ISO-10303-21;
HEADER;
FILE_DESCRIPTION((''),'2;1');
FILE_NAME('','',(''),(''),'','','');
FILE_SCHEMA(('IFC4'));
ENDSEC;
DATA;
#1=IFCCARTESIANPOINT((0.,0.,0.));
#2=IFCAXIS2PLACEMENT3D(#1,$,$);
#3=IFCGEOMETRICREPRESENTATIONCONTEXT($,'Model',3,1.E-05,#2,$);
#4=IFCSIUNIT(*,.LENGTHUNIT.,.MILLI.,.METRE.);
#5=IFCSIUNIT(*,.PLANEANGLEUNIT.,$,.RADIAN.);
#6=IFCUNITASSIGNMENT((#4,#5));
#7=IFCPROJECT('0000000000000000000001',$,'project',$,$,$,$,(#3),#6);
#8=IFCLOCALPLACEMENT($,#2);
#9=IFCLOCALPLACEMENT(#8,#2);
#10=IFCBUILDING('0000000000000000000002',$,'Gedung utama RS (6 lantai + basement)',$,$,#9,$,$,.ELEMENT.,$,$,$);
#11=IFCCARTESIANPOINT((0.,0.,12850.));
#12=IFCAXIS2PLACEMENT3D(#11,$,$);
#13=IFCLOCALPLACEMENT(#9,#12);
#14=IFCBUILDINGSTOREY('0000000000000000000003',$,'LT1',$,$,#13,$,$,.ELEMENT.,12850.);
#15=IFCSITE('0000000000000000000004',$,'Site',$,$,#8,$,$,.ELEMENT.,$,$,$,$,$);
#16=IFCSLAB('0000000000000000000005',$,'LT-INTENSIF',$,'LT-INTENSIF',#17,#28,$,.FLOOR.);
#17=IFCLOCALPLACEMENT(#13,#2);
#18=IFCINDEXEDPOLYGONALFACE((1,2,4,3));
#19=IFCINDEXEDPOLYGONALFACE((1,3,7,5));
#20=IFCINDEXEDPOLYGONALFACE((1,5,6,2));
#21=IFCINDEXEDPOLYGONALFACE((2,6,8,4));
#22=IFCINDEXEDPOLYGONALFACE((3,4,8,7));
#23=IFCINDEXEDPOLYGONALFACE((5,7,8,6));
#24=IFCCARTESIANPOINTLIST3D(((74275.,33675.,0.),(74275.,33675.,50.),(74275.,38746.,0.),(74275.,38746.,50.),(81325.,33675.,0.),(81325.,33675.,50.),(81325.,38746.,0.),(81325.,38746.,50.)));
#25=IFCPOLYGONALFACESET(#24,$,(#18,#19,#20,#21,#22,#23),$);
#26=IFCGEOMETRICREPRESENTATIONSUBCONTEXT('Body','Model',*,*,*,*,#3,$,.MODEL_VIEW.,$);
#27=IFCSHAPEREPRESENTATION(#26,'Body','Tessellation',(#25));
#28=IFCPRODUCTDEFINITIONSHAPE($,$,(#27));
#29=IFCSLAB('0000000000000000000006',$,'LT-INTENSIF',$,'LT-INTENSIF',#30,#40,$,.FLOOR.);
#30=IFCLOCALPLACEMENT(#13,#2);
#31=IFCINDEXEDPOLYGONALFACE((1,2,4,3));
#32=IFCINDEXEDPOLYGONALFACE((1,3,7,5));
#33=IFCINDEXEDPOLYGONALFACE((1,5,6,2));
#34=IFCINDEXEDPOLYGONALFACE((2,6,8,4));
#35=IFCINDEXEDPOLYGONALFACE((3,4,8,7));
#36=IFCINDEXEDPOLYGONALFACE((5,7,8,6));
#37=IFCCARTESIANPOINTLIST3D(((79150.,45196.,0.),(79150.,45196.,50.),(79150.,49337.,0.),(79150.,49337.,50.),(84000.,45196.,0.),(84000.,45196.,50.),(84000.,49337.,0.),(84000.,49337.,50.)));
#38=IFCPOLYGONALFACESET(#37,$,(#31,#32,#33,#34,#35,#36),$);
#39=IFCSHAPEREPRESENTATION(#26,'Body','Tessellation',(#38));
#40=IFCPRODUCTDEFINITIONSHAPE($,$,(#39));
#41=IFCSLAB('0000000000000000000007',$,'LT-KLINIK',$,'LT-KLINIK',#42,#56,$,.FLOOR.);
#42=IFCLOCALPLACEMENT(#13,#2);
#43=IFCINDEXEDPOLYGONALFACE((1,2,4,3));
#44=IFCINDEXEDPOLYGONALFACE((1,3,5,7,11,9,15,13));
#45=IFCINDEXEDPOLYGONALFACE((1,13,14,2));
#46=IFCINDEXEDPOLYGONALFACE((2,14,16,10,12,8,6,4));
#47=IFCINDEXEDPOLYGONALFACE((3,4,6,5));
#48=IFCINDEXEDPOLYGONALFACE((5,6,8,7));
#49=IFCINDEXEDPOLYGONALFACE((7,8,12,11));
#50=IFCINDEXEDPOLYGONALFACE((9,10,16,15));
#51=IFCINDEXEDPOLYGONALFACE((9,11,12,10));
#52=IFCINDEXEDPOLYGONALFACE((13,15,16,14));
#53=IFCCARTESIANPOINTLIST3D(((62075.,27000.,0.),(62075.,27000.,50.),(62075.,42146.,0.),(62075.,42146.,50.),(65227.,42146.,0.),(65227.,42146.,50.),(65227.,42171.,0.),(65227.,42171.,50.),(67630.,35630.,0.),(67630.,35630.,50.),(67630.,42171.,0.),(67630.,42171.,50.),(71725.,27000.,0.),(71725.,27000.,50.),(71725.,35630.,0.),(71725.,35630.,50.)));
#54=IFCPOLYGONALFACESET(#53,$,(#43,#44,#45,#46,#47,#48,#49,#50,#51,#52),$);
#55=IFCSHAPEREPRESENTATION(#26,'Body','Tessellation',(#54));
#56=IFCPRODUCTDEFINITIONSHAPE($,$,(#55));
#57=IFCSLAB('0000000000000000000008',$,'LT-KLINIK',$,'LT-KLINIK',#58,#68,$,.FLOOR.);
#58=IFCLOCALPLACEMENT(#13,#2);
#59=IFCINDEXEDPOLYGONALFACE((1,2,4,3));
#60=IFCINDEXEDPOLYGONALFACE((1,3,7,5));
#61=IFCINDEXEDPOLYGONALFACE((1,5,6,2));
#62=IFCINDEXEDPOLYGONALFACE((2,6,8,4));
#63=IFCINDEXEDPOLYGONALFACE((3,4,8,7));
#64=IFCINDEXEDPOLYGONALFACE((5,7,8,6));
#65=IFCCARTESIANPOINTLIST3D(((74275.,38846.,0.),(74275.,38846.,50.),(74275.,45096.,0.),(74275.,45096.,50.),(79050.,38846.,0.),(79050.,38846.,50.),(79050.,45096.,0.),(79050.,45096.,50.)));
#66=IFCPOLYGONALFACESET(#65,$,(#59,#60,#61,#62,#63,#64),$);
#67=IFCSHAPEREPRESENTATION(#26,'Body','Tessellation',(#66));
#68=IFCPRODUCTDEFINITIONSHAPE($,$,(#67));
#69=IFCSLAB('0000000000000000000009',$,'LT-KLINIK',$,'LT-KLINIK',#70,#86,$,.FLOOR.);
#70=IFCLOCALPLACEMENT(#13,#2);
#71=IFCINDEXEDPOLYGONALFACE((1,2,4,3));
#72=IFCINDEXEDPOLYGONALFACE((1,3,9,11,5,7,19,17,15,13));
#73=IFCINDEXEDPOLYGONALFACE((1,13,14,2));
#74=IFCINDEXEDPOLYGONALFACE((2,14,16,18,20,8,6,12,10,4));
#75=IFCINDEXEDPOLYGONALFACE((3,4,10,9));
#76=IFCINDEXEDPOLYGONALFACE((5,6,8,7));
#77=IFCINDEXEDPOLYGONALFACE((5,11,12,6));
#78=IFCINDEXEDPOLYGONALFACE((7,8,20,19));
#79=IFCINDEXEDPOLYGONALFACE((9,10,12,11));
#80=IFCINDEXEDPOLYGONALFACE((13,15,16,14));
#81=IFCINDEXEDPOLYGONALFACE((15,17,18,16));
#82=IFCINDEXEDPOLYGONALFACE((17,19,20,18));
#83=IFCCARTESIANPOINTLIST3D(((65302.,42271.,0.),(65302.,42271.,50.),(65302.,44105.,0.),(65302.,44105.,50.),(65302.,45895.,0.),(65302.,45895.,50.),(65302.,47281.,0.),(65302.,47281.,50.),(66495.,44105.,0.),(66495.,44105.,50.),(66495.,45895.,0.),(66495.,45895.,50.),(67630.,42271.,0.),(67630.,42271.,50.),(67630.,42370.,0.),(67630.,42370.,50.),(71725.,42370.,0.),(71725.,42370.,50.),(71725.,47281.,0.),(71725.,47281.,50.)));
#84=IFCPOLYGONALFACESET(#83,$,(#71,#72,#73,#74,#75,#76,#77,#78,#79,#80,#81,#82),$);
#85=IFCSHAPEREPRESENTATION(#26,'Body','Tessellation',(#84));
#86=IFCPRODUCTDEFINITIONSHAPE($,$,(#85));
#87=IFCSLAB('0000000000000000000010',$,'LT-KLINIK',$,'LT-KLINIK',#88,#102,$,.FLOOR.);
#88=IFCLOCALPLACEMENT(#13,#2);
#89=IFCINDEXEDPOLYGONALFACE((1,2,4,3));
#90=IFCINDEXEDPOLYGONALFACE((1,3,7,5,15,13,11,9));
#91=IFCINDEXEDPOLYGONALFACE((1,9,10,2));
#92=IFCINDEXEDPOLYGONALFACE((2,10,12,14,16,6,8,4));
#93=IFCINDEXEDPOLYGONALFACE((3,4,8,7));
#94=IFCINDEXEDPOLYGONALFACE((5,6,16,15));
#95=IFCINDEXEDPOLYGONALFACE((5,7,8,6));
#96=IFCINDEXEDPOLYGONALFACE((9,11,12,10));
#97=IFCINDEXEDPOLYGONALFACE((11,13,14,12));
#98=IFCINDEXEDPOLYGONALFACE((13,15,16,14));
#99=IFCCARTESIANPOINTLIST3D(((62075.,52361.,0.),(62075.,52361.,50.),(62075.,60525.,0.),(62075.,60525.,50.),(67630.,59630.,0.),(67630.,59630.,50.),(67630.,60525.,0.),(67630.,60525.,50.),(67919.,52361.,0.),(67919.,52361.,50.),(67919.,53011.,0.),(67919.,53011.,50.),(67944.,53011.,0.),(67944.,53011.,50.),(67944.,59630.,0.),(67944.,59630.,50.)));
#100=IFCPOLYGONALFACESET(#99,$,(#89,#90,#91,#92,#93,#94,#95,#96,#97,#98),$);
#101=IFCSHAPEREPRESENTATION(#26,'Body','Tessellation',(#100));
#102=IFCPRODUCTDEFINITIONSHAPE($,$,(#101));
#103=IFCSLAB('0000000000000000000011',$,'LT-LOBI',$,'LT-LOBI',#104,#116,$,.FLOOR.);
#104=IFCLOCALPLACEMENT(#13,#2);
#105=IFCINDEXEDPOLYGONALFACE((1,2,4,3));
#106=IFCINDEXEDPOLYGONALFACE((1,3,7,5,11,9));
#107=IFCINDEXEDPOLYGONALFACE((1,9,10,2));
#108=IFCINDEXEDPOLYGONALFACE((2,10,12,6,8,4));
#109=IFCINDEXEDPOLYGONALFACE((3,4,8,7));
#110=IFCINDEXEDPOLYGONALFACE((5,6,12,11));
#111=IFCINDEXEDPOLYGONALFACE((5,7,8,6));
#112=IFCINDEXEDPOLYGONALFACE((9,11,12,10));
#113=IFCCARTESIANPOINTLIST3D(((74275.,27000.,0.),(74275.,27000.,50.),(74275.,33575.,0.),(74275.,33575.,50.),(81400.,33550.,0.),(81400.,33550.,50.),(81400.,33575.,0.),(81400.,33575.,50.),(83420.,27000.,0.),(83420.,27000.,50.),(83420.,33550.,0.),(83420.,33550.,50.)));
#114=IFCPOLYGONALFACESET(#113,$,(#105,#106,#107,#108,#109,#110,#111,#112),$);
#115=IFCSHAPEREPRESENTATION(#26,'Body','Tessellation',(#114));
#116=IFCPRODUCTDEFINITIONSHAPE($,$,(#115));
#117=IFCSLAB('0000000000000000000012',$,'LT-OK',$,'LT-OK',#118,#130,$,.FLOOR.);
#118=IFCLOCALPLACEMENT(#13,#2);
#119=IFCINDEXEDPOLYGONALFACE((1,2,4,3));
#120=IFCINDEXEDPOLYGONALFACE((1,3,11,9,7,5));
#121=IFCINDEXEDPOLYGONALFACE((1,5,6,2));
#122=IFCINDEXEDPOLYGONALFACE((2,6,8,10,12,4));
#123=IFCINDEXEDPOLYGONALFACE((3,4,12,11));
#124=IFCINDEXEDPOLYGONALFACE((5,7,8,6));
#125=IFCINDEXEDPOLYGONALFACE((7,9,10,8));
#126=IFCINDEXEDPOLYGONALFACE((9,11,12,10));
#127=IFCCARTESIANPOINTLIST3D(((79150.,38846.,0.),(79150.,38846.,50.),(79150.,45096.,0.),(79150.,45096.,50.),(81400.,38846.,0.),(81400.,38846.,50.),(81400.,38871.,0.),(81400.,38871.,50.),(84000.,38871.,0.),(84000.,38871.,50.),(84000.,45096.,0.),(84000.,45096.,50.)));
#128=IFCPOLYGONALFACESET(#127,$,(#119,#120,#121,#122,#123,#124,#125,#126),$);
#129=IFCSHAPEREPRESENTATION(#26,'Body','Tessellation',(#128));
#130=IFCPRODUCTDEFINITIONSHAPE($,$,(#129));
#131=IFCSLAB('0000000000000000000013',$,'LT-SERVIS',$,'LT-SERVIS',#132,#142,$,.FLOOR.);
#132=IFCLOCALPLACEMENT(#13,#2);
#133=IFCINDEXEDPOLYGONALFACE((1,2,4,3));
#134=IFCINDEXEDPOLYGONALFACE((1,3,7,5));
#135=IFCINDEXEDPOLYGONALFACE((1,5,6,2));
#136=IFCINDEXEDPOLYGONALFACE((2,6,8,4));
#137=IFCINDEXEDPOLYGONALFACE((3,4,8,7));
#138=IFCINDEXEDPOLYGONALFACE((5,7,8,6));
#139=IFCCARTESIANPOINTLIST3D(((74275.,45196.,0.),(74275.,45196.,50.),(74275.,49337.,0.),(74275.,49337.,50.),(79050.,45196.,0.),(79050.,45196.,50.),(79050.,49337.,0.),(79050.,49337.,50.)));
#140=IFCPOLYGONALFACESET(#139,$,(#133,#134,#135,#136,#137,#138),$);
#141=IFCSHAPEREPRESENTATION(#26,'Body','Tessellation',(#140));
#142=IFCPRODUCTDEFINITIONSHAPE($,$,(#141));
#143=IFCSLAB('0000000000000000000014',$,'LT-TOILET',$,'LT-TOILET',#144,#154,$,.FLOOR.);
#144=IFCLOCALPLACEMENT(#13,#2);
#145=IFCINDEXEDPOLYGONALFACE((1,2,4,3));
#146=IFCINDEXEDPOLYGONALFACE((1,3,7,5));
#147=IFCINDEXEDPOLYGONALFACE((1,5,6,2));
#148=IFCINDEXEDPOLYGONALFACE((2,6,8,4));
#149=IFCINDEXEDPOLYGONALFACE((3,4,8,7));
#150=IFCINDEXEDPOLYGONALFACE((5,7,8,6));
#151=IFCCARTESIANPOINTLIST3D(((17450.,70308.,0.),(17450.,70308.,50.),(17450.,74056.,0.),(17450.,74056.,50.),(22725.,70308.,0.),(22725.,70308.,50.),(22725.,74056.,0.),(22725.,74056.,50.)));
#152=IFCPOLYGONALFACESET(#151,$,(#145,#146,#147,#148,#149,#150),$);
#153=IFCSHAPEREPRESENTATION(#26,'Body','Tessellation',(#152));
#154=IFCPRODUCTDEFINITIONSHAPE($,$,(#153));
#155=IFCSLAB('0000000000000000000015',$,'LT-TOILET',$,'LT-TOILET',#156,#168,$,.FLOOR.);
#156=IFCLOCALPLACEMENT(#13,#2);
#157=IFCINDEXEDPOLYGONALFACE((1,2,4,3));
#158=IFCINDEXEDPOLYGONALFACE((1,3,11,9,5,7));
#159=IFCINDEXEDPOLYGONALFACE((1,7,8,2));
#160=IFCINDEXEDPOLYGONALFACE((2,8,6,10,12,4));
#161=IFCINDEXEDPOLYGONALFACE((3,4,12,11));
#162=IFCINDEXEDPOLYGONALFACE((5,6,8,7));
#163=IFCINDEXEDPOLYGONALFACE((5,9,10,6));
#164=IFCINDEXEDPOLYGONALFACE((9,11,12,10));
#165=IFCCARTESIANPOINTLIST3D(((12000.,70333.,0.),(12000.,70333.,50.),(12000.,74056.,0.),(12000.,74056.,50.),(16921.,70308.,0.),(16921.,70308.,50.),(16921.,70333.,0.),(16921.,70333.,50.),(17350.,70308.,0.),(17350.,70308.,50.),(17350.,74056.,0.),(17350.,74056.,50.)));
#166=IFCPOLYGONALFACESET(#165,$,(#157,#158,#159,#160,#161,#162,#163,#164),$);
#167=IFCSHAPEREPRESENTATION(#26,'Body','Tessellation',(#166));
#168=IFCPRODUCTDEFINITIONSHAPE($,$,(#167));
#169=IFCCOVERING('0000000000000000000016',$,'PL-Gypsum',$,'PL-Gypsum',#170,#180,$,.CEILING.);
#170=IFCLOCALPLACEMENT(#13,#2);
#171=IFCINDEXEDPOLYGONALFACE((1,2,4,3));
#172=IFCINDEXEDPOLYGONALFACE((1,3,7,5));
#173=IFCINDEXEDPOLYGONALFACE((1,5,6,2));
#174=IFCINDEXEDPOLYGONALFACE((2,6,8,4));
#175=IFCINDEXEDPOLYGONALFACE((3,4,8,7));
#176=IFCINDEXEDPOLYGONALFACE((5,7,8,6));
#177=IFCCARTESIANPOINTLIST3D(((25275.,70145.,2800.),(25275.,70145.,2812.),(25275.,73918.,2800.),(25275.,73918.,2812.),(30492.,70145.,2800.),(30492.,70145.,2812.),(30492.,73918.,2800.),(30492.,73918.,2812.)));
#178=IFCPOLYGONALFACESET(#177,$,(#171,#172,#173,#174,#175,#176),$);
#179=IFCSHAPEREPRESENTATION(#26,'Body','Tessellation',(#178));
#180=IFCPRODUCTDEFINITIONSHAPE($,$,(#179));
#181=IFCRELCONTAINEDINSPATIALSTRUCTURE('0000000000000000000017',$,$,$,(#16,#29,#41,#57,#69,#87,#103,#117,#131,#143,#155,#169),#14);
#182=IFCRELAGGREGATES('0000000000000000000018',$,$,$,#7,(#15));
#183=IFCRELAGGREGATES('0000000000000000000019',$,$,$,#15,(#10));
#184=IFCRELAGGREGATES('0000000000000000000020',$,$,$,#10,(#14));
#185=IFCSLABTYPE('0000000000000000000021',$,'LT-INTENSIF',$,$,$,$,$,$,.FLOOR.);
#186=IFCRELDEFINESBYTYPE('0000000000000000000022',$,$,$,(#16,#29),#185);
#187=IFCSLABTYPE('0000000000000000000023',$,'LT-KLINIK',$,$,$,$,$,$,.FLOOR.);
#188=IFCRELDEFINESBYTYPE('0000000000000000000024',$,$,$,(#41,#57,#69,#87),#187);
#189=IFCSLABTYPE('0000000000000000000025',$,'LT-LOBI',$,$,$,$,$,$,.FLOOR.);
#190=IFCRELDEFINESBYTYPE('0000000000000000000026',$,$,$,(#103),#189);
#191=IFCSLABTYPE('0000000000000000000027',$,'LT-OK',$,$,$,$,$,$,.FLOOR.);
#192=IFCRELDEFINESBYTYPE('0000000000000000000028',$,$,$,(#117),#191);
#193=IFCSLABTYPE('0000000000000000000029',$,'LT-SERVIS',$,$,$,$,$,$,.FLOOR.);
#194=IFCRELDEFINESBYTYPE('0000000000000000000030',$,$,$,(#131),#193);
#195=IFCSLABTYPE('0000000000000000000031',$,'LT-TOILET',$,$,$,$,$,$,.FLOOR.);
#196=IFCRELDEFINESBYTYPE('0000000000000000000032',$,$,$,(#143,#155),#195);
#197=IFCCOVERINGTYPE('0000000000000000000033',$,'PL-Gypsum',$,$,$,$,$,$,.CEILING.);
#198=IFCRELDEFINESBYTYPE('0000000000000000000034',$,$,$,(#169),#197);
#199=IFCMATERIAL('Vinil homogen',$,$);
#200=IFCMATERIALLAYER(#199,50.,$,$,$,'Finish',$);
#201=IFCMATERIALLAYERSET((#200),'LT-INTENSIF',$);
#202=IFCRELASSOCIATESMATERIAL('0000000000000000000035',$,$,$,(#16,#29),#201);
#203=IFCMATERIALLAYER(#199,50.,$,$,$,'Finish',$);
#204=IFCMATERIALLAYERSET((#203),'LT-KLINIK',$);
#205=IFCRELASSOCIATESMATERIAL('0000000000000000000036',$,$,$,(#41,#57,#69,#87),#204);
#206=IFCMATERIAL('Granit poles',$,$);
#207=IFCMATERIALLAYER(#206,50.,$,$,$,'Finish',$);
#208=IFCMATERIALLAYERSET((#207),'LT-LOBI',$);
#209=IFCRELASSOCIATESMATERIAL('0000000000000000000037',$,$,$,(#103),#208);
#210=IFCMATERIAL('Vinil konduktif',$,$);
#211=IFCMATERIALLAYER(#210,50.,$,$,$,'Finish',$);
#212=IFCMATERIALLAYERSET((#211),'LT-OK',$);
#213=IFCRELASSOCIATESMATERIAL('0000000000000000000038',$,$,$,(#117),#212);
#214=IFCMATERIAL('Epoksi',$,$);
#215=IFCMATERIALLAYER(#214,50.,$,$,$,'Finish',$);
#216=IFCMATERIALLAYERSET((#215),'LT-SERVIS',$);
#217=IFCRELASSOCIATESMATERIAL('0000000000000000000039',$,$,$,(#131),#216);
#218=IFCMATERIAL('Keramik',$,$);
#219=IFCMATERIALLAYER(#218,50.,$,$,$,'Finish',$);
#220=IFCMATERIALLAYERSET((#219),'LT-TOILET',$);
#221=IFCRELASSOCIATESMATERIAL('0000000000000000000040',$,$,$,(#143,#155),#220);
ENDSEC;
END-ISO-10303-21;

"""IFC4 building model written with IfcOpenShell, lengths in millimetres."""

from ifc_helpers import new_model, si_unit, frame, origin, place, context, subcontext, project, spatial, polyline, outline, extrude, material, layer, layer_set, layer_usage, type_object, element, save


model = new_model("IFC4")

# Units and contexts
model_context = context("Model", 3, precision=1e-05, world=origin())
body_context = subcontext(model_context, "Body", "Model", "MODEL_VIEW")
ifc_project = project(units=[si_unit("LENGTHUNIT", "METRE", prefix="MILLI"), si_unit("PLANEANGLEUNIT", "RADIAN")], contexts=[model_context])

# Site, building, storey
site_placement = place(None, origin())
site = spatial("IfcSite", under=ifc_project, at=site_placement, Name="Site", CompositionType="ELEMENT")
building_placement = place(site_placement, origin())
building = spatial("IfcBuilding", under=site, at=building_placement, Name="Gedung utama RS (6 lantai + basement)", CompositionType="ELEMENT")
storey_placement = place(building_placement, frame((0.0, 0.0, 12850.0)))
storey = spatial("IfcBuildingStorey", under=building, at=storey_placement, Name="LT1", CompositionType="ELEMENT", Elevation=12850.0)

# Slabs
ifc_material_1 = material(Name="Vinil homogen")
ifc_layer_1 = layer(ifc_material_1, 50.0, Category="Finish")
ifc_layer_set_1 = layer_set([ifc_layer_1], Name="LT-INTENSIF")
ifc_layer_usage_1 = layer_usage(ifc_layer_set_1, "AXIS3", "NEGATIVE", 50.0)
slab_type_1 = type_object("IfcSlabType", Name="LT-INTENSIF", PredefinedType="FLOOR")
slab_1_placement = place(storey_placement, origin())
element("IfcSlab", 1, at=slab_1_placement, inside=storey, type_object=slab_type_1, material=ifc_layer_usage_1, Name="LT-INTENSIF", ObjectType="LT-INTENSIF", PredefinedType="FLOOR", context=body_context, shape_type="SweptSolid", body=[
    extrude(outline(polyline([(74275.0, 33675.0), (81325.0, 33675.0), (81325.0, 38746.0), (74275.0, 38746.0), (74275.0, 33675.0)])), origin(), (0.0, 0.0, 1.0), 50.0),
])
slab_2_placement = place(storey_placement, origin())
element("IfcSlab", 2, at=slab_2_placement, inside=storey, type_object=slab_type_1, material=ifc_layer_usage_1, Name="LT-INTENSIF", ObjectType="LT-INTENSIF", PredefinedType="FLOOR", context=body_context, shape_type="SweptSolid", body=[
    extrude(outline(polyline([(79150.0, 45196.0), (84000.0, 45196.0), (84000.0, 49337.0), (79150.0, 49337.0), (79150.0, 45196.0)])), origin(), (0.0, 0.0, 1.0), 50.0),
])
ifc_layer_2 = layer(ifc_material_1, 50.0, Category="Finish")
ifc_layer_set_2 = layer_set([ifc_layer_2], Name="LT-KLINIK")
ifc_layer_usage_2 = layer_usage(ifc_layer_set_2, "AXIS3", "NEGATIVE", 50.0)
slab_type_2 = type_object("IfcSlabType", Name="LT-KLINIK", PredefinedType="FLOOR")
slab_3_placement = place(storey_placement, origin())
element("IfcSlab", 3, at=slab_3_placement, inside=storey, type_object=slab_type_2, material=ifc_layer_usage_2, Name="LT-KLINIK", ObjectType="LT-KLINIK", PredefinedType="FLOOR", context=body_context, shape_type="SweptSolid", body=[
    extrude(outline(polyline([(62075.0, 27000.0), (71725.0, 27000.0), (71725.0, 35630.0), (67630.0, 35630.0), (67630.0, 42171.0), (65227.0, 42171.0), (65227.0, 42146.0), (62075.0, 42146.0), (62075.0, 27000.0)])), origin(), (0.0, 0.0, 1.0), 50.0),
])
slab_4_placement = place(storey_placement, origin())
element("IfcSlab", 4, at=slab_4_placement, inside=storey, type_object=slab_type_2, material=ifc_layer_usage_2, Name="LT-KLINIK", ObjectType="LT-KLINIK", PredefinedType="FLOOR", context=body_context, shape_type="SweptSolid", body=[
    extrude(outline(polyline([(74275.0, 38846.0), (79050.0, 38846.0), (79050.0, 45096.0), (74275.0, 45096.0), (74275.0, 38846.0)])), origin(), (0.0, 0.0, 1.0), 50.0),
])
slab_5_placement = place(storey_placement, origin())
element("IfcSlab", 5, at=slab_5_placement, inside=storey, type_object=slab_type_2, material=ifc_layer_usage_2, Name="LT-KLINIK", ObjectType="LT-KLINIK", PredefinedType="FLOOR", context=body_context, shape_type="SweptSolid", body=[
    extrude(outline(polyline([(65302.0, 42271.0), (67630.0, 42271.0), (67630.0, 42370.0), (71725.0, 42370.0), (71725.0, 47281.0), (65302.0, 47281.0), (65302.0, 45895.0), (66495.0, 45895.0), (66495.0, 44105.0), (65302.0, 44105.0), (65302.0, 42271.0)])), origin(), (0.0, 0.0, 1.0), 50.0),
])
slab_6_placement = place(storey_placement, origin())
element("IfcSlab", 6, at=slab_6_placement, inside=storey, type_object=slab_type_2, material=ifc_layer_usage_2, Name="LT-KLINIK", ObjectType="LT-KLINIK", PredefinedType="FLOOR", context=body_context, shape_type="SweptSolid", body=[
    extrude(outline(polyline([(62075.0, 52361.0), (67919.0, 52361.0), (67919.0, 53011.0), (67944.0, 53011.0), (67944.0, 59630.0), (67630.0, 59630.0), (67630.0, 60525.0), (62075.0, 60525.0), (62075.0, 52361.0)])), origin(), (0.0, 0.0, 1.0), 50.0),
])
ifc_material_2 = material(Name="Granit poles")
ifc_layer_3 = layer(ifc_material_2, 50.0, Category="Finish")
ifc_layer_set_3 = layer_set([ifc_layer_3], Name="LT-LOBI")
ifc_layer_usage_3 = layer_usage(ifc_layer_set_3, "AXIS3", "NEGATIVE", 50.0)
slab_type_3 = type_object("IfcSlabType", Name="LT-LOBI", PredefinedType="FLOOR")
slab_7_placement = place(storey_placement, origin())
element("IfcSlab", 7, at=slab_7_placement, inside=storey, type_object=slab_type_3, material=ifc_layer_usage_3, Name="LT-LOBI", ObjectType="LT-LOBI", PredefinedType="FLOOR", context=body_context, shape_type="SweptSolid", body=[
    extrude(outline(polyline([(74275.0, 27000.0), (83420.0, 27000.0), (83420.0, 33550.0), (81400.0, 33550.0), (81400.0, 33575.0), (74275.0, 33575.0), (74275.0, 27000.0)])), origin(), (0.0, 0.0, 1.0), 50.0),
])
ifc_material_3 = material(Name="Vinil konduktif")
ifc_layer_4 = layer(ifc_material_3, 50.0, Category="Finish")
ifc_layer_set_4 = layer_set([ifc_layer_4], Name="LT-OK")
ifc_layer_usage_4 = layer_usage(ifc_layer_set_4, "AXIS3", "NEGATIVE", 50.0)
slab_type_4 = type_object("IfcSlabType", Name="LT-OK", PredefinedType="FLOOR")
slab_8_placement = place(storey_placement, origin())
element("IfcSlab", 8, at=slab_8_placement, inside=storey, type_object=slab_type_4, material=ifc_layer_usage_4, Name="LT-OK", ObjectType="LT-OK", PredefinedType="FLOOR", context=body_context, shape_type="SweptSolid", body=[
    extrude(outline(polyline([(79150.0, 38846.0), (81400.0, 38846.0), (81400.0, 38871.0), (84000.0, 38871.0), (84000.0, 45096.0), (79150.0, 45096.0), (79150.0, 38846.0)])), origin(), (0.0, 0.0, 1.0), 50.0),
])
ifc_material_4 = material(Name="Epoksi")
ifc_layer_5 = layer(ifc_material_4, 50.0, Category="Finish")
ifc_layer_set_5 = layer_set([ifc_layer_5], Name="LT-SERVIS")
ifc_layer_usage_5 = layer_usage(ifc_layer_set_5, "AXIS3", "NEGATIVE", 50.0)
slab_type_5 = type_object("IfcSlabType", Name="LT-SERVIS", PredefinedType="FLOOR")
slab_9_placement = place(storey_placement, origin())
element("IfcSlab", 9, at=slab_9_placement, inside=storey, type_object=slab_type_5, material=ifc_layer_usage_5, Name="LT-SERVIS", ObjectType="LT-SERVIS", PredefinedType="FLOOR", context=body_context, shape_type="SweptSolid", body=[
    extrude(outline(polyline([(74275.0, 45196.0), (79050.0, 45196.0), (79050.0, 49337.0), (74275.0, 49337.0), (74275.0, 45196.0)])), origin(), (0.0, 0.0, 1.0), 50.0),
])
ifc_material_5 = material(Name="Keramik")
ifc_layer_6 = layer(ifc_material_5, 50.0, Category="Finish")
ifc_layer_set_6 = layer_set([ifc_layer_6], Name="LT-TOILET")
ifc_layer_usage_6 = layer_usage(ifc_layer_set_6, "AXIS3", "NEGATIVE", 50.0)
slab_type_6 = type_object("IfcSlabType", Name="LT-TOILET", PredefinedType="FLOOR")
slab_10_placement = place(storey_placement, origin())
element("IfcSlab", 10, at=slab_10_placement, inside=storey, type_object=slab_type_6, material=ifc_layer_usage_6, Name="LT-TOILET", ObjectType="LT-TOILET", PredefinedType="FLOOR", context=body_context, shape_type="SweptSolid", body=[
    extrude(outline(polyline([(17450.0, 70308.0), (22725.0, 70308.0), (22725.0, 74056.0), (17450.0, 74056.0), (17450.0, 70308.0)])), origin(), (0.0, 0.0, 1.0), 50.0),
])
slab_11_placement = place(storey_placement, origin())
element("IfcSlab", 11, at=slab_11_placement, inside=storey, type_object=slab_type_6, material=ifc_layer_usage_6, Name="LT-TOILET", ObjectType="LT-TOILET", PredefinedType="FLOOR", context=body_context, shape_type="SweptSolid", body=[
    extrude(outline(polyline([(16921.0, 70308.0), (17350.0, 70308.0), (17350.0, 74056.0), (12000.0, 74056.0), (12000.0, 70333.0), (16921.0, 70333.0), (16921.0, 70308.0)])), origin(), (0.0, 0.0, 1.0), 50.0),
])

# Covering
covering_type = type_object("IfcCoveringType", Name="PL-Gypsum", PredefinedType="CEILING")
covering_1_placement = place(storey_placement, origin())
element("IfcCovering", 12, at=covering_1_placement, inside=storey, type_object=covering_type, Name="PL-Gypsum", ObjectType="PL-Gypsum", PredefinedType="CEILING", context=body_context, shape_type="SweptSolid", body=[
    extrude(outline(polyline([(25275.0, 70145.0), (30492.0, 70145.0), (30492.0, 73918.0), (25275.0, 73918.0), (25275.0, 70145.0)])), frame((0.0, 0.0, 2800.0)), (0.0, 0.0, 1.0), 12.0),
])

save(model, "model.ifc")
